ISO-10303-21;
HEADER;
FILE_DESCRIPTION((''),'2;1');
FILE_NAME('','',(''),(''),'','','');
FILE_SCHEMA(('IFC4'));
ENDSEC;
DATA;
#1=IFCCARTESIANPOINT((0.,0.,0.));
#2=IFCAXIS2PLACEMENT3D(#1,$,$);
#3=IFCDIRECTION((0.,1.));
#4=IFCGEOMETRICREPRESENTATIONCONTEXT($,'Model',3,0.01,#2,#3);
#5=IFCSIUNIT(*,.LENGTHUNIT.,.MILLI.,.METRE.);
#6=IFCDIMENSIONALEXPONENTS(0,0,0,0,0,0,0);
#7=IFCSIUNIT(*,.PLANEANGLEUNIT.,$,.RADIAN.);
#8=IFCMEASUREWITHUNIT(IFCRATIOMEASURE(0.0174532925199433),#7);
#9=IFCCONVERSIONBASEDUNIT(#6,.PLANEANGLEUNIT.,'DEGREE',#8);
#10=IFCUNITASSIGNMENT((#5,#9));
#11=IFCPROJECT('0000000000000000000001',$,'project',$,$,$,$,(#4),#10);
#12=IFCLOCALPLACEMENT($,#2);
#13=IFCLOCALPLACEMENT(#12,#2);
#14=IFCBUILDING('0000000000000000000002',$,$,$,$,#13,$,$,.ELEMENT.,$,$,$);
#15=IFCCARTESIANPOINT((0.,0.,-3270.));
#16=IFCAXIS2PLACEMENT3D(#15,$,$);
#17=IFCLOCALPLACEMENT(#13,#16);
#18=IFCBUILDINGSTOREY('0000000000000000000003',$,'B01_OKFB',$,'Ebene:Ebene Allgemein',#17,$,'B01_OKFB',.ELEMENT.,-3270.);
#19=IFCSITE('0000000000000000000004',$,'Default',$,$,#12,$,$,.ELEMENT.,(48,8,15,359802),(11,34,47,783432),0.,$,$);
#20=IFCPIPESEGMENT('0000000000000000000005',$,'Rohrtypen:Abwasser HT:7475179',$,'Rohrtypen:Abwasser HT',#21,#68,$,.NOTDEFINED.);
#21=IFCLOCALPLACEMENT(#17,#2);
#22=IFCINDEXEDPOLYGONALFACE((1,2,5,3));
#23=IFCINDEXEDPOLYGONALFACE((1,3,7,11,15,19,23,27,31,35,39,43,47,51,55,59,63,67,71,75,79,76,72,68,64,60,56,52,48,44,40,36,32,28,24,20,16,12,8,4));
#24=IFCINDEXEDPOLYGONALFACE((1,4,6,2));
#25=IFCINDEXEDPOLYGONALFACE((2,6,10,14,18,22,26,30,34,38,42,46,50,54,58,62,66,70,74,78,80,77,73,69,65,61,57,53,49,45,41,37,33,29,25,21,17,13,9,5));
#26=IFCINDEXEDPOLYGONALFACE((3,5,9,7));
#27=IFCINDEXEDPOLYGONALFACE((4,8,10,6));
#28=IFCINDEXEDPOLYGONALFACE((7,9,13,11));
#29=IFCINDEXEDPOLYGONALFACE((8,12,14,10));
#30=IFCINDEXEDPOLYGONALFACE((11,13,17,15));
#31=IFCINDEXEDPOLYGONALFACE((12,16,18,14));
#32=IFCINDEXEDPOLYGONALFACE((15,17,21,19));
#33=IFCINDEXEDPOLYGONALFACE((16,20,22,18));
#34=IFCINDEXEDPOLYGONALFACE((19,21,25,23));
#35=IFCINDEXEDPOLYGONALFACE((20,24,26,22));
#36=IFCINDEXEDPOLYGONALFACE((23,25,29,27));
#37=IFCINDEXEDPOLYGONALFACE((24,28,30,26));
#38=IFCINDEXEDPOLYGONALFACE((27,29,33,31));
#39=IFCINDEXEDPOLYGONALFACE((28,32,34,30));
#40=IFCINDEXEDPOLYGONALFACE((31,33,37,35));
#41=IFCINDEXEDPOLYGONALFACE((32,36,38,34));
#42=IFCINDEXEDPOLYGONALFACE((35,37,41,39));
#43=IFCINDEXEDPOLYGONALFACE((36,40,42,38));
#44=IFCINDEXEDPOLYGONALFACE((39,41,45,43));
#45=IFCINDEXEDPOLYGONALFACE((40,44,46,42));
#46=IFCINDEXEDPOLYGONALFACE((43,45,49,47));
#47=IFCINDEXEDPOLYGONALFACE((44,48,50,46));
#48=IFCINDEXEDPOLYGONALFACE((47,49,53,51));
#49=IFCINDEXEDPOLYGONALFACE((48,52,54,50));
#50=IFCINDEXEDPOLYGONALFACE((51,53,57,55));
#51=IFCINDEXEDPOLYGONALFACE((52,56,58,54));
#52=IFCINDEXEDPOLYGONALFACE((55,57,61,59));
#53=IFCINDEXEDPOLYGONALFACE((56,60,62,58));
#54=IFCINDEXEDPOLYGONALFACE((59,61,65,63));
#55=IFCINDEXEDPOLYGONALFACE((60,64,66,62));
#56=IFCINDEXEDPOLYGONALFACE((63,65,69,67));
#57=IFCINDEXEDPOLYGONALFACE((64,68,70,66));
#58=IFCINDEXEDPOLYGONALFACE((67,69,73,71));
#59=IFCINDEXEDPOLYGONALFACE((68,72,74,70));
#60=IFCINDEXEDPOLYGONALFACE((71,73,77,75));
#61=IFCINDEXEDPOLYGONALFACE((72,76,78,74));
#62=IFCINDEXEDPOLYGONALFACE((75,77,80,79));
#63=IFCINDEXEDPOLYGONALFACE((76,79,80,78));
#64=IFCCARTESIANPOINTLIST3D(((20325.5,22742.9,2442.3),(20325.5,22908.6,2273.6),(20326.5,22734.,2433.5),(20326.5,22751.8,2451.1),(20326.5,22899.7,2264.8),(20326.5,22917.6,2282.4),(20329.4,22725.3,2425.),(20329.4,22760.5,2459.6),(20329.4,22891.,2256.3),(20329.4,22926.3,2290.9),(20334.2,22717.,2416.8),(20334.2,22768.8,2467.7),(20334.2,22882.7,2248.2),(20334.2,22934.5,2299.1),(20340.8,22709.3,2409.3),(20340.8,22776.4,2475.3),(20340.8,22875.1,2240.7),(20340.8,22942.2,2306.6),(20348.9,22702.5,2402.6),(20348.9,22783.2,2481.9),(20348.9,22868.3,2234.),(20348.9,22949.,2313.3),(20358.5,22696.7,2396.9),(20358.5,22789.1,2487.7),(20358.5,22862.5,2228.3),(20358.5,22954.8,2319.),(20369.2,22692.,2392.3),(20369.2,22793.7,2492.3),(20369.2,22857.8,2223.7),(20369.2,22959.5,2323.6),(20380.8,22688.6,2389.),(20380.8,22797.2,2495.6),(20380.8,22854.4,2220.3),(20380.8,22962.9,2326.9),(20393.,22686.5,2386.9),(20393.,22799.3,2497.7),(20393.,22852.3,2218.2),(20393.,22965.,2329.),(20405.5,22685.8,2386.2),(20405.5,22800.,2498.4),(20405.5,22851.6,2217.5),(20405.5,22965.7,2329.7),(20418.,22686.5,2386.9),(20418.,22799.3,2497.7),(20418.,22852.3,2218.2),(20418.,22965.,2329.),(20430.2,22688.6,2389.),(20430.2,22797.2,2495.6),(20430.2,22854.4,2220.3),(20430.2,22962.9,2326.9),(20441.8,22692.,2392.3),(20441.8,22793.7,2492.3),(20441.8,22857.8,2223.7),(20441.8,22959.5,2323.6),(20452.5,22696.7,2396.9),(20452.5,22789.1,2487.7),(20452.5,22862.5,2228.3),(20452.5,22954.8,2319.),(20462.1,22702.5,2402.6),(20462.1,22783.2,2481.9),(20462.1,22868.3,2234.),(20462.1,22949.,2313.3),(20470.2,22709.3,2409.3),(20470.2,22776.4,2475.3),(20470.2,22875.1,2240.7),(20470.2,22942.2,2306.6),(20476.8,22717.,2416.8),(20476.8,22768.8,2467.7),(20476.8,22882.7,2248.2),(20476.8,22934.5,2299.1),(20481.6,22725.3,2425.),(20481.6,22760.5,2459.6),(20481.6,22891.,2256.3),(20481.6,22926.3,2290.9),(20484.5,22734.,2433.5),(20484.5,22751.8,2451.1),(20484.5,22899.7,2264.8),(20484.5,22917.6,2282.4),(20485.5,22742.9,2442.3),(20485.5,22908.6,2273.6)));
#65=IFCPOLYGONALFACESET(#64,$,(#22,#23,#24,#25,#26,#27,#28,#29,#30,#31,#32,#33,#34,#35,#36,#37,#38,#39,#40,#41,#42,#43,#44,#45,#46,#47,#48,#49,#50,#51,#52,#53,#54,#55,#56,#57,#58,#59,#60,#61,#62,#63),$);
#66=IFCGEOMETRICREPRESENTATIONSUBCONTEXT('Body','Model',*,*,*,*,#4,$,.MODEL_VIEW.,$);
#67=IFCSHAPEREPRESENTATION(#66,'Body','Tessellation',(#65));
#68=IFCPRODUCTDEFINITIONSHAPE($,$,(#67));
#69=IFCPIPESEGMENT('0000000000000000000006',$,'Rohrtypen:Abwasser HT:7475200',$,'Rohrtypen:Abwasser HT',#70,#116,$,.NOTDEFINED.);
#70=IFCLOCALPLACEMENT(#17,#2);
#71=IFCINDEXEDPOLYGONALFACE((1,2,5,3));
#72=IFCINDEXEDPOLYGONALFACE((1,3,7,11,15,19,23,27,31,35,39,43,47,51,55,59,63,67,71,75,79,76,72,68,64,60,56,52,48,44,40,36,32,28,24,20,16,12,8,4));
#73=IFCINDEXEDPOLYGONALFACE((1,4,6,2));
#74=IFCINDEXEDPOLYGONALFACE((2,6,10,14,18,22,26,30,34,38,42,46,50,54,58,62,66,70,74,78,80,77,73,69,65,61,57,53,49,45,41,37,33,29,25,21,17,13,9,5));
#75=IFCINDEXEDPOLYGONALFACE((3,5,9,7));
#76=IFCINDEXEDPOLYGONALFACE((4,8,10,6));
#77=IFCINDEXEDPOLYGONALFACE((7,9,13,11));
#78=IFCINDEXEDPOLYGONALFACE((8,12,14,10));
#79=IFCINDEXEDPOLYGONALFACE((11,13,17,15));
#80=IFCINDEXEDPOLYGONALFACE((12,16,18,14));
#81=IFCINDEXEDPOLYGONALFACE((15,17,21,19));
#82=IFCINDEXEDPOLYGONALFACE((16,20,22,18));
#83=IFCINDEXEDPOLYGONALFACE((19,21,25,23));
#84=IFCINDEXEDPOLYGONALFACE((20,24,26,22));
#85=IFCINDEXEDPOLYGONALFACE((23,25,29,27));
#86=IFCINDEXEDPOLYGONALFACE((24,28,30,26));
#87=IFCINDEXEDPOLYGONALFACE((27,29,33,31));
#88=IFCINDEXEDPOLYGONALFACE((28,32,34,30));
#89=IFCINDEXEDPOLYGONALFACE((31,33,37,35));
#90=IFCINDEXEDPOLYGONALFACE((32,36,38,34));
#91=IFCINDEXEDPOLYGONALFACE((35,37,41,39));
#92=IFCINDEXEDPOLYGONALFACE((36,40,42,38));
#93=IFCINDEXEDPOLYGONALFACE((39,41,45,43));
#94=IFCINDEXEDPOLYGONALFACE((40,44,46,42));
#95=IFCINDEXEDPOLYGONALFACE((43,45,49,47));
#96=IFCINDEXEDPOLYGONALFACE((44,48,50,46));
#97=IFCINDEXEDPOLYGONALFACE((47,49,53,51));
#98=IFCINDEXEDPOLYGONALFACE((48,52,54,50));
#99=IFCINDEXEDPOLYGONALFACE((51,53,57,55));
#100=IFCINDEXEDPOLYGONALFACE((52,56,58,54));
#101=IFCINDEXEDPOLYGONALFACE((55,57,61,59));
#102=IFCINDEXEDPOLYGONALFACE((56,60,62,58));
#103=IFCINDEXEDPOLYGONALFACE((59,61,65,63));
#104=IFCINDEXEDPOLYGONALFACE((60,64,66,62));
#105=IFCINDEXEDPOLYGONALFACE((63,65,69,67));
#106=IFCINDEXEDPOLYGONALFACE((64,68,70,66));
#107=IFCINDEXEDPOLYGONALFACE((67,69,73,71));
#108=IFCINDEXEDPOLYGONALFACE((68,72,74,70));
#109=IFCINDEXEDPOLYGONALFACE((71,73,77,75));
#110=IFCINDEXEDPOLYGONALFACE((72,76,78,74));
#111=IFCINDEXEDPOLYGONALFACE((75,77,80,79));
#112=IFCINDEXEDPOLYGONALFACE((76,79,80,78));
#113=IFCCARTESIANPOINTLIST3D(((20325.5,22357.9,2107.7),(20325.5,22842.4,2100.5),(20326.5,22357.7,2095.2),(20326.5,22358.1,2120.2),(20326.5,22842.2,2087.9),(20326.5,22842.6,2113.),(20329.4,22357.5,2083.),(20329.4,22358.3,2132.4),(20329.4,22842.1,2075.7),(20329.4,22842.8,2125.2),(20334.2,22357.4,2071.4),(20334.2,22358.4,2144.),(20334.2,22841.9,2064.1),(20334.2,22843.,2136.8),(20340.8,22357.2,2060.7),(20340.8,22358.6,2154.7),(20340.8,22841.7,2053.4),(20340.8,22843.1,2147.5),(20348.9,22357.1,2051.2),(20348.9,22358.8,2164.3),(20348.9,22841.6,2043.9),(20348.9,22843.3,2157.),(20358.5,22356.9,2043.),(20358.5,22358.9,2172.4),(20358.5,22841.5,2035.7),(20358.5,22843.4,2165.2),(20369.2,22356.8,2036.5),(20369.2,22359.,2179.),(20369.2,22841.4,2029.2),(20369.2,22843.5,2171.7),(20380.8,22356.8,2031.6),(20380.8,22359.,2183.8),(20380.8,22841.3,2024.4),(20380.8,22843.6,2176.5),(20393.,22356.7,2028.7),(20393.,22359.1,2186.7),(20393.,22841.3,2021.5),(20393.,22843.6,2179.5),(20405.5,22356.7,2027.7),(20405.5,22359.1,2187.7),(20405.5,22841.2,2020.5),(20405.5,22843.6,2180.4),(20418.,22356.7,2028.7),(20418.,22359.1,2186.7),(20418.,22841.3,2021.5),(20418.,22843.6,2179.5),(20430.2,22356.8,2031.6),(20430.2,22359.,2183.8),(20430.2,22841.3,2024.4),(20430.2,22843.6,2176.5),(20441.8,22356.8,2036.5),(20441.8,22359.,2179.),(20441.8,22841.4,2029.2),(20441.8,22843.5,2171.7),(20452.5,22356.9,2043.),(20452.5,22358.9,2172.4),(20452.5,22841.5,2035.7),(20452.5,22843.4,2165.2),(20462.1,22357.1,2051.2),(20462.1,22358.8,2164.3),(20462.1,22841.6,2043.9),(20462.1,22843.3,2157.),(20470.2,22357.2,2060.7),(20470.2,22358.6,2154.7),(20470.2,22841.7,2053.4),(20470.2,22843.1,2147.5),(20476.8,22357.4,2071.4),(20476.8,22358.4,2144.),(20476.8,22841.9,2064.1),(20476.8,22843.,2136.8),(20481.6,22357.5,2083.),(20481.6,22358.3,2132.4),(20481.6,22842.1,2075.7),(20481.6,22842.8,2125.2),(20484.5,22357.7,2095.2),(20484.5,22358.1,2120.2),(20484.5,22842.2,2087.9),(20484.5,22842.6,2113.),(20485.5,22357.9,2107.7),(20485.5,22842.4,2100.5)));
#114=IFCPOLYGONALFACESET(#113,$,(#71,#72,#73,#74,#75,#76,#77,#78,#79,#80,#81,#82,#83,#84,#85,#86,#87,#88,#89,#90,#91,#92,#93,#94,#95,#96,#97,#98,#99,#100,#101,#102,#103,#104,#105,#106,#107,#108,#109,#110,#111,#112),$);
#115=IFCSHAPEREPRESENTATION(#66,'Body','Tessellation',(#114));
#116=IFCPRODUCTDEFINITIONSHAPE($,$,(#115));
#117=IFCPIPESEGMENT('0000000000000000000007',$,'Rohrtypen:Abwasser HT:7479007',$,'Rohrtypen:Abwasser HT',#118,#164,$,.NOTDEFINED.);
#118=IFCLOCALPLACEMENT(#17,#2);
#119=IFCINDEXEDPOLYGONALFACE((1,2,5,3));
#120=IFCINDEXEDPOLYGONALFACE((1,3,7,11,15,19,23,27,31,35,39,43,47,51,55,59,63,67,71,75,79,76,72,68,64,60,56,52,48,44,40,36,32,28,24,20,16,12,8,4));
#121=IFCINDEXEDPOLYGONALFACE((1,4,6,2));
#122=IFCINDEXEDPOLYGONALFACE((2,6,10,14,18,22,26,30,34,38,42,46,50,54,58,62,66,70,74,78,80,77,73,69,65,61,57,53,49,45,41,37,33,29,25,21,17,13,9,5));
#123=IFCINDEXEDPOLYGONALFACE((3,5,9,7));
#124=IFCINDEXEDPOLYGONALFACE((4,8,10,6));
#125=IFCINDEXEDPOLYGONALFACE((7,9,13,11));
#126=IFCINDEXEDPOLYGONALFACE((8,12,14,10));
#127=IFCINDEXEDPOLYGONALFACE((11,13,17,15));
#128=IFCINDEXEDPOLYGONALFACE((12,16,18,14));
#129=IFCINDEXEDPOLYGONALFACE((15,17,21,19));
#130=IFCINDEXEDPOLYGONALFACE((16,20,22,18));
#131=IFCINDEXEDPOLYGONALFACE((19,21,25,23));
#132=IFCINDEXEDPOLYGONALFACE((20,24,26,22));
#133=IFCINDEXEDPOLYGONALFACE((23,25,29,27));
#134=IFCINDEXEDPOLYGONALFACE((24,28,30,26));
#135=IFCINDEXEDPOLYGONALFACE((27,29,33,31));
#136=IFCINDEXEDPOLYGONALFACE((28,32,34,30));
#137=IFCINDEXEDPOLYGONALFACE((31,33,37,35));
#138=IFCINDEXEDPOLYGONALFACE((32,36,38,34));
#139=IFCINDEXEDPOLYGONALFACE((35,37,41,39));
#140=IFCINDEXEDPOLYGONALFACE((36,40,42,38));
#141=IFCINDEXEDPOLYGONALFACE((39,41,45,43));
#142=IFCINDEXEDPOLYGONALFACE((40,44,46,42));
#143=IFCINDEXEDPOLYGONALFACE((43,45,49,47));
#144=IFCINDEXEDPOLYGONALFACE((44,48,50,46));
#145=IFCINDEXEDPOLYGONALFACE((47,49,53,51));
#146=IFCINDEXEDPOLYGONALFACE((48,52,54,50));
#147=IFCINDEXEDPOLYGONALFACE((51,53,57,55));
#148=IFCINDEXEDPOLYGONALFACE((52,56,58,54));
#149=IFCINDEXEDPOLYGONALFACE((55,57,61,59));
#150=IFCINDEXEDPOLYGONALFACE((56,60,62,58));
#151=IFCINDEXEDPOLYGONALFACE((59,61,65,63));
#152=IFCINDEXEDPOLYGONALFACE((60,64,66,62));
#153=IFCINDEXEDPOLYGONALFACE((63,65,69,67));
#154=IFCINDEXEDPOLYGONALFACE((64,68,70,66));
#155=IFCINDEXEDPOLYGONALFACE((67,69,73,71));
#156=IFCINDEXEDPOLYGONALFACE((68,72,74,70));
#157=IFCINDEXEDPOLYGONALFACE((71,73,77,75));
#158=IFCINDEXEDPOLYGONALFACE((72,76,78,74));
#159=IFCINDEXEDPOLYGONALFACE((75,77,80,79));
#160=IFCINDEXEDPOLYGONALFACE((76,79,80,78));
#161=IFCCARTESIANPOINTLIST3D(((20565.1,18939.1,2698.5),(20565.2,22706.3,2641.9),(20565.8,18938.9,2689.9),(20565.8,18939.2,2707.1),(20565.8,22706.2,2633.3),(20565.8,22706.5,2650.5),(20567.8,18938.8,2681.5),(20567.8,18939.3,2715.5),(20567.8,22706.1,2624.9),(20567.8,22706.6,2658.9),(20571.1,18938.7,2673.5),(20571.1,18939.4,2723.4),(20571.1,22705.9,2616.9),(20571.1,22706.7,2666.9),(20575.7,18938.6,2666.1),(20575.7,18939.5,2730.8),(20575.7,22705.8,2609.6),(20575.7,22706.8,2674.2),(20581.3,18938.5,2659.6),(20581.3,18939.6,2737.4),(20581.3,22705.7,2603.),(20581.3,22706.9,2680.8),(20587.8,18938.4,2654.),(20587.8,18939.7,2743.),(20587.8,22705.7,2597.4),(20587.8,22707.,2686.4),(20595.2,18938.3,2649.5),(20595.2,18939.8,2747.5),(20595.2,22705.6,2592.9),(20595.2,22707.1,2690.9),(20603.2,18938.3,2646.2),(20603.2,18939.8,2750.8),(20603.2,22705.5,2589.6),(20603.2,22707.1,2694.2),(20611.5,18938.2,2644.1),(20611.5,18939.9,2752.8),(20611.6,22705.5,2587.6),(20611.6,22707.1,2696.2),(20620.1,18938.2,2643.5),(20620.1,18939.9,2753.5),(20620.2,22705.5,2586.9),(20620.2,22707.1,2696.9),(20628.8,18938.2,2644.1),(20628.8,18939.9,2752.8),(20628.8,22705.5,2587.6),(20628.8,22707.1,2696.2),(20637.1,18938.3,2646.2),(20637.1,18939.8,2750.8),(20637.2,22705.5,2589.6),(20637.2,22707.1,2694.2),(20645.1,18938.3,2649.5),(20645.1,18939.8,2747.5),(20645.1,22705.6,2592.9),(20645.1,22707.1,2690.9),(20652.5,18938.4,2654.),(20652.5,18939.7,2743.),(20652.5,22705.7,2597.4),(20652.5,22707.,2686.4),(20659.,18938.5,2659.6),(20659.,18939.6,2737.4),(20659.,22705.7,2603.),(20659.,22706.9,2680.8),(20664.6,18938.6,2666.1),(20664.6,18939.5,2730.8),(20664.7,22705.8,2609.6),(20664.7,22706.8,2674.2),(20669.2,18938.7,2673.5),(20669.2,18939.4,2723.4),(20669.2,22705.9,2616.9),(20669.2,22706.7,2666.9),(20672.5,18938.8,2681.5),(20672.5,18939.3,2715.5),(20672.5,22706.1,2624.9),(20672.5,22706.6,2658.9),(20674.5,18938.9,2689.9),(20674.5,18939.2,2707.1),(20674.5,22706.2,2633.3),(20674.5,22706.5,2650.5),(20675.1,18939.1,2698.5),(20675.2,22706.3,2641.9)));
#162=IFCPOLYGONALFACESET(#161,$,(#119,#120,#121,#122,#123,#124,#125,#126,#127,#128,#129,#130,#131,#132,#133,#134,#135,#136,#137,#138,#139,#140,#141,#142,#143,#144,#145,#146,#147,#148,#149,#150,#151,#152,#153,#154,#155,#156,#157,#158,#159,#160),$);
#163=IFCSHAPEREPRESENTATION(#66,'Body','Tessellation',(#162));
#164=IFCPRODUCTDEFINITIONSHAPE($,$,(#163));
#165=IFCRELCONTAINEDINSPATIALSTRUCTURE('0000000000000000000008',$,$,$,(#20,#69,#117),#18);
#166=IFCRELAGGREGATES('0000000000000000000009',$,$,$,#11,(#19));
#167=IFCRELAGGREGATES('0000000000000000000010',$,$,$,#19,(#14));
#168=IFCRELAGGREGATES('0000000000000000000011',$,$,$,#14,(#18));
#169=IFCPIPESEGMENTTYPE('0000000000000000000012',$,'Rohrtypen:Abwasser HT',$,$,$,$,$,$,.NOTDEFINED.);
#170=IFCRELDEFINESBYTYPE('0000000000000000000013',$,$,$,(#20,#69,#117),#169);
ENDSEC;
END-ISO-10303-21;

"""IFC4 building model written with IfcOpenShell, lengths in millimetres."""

from ifc_helpers import new_model, entity, si_unit, converted_unit, direction, frame, origin, place, context, subcontext, project, spatial, indexed_curve, outline, extrude, type_object, element, save


model = new_model("IFC4")

# Units and contexts
model_context = context("Model", 3, precision=0.01, world=origin(), true_north=direction((0.0, 1.0)))
body_context = subcontext(model_context, "Body", "Model", "MODEL_VIEW")
ifc_project = project(units=[si_unit("LENGTHUNIT", "METRE", prefix="MILLI"), converted_unit("PLANEANGLEUNIT", "DEGREE", entity("IfcRatioMeasure", 0.0174532925199433), si_unit("PLANEANGLEUNIT", "RADIAN"), dimensions=[0, 0, 0, 0, 0, 0, 0])], contexts=[model_context])

# Site, building, storey
site_placement = place(None, origin())
site = spatial("IfcSite", under=ifc_project, at=site_placement, Name="Default", CompositionType="ELEMENT", RefLatitude=(48, 8, 15, 359802), RefLongitude=(11, 34, 47, 783432), RefElevation=0.0)
building_placement = place(site_placement, origin())
building = spatial("IfcBuilding", under=site, at=building_placement, CompositionType="ELEMENT")
storey_placement = place(building_placement, frame((0.0, 0.0, -3270.0)))
storey = spatial("IfcBuildingStorey", under=building, at=storey_placement, Name="B01_OKFB", ObjectType="Ebene:Ebene Allgemein", LongName="B01_OKFB", CompositionType="ELEMENT", Elevation=-3270.0)

# Pipe segments
pipe_segment_type_1 = type_object("IfcPipeSegmentType", Name="Rohrtypen:Abwasser HT", PredefinedType="NOTDEFINED")
pipe_segment_1_placement = place(storey_placement, origin())
element("IfcPipeSegment", 1, at=pipe_segment_1_placement, inside=storey, type_object=pipe_segment_type_1, Name="Rohrtypen:Abwasser HT:7475179", ObjectType="Rohrtypen:Abwasser HT", PredefinedType="NOTDEFINED", context=body_context, shape_type="SweptSolid", body=[
    extrude(outline(indexed_curve([(80.0, 0.0), (79.0, 12.5), (76.1, 24.7), (71.3, 36.3), (64.7, 47.0), (56.6, 56.6), (47.0, 64.7), (36.3, 71.3), (24.7, 76.1), (12.5, 79.0), (0.0, 80.0), (-12.5, 79.0), (-24.7, 76.1), (-36.3, 71.3), (-47.0, 64.7), (-56.6, 56.6), (-64.7, 47.0), (-71.3, 36.3), (-76.1, 24.7), (-79.0, 12.5), (-80.0, 0.0), (-79.0, -12.5), (-76.1, -24.7), (-71.3, -36.3), (-64.7, -47.0), (-56.6, -56.6), (-47.0, -64.7), (-36.3, -71.3), (-24.7, -76.1), (-12.5, -79.0), (0.0, -80.0), (12.5, -79.0), (24.7, -76.1), (36.3, -71.3), (47.0, -64.7), (56.6, -56.6), (64.7, -47.0), (71.3, -36.3), (76.1, -24.7), (79.0, -12.5), (80.0, 0.0)], self_intersect=False)), frame((20405.5, 22742.9, 2442.3), z_axis=(0.0, 0.700866, -0.713293), x_axis=(-1.0, 0.0, 0.0)), (0.0, 0.0, 1.0), 236.5),
])
pipe_segment_2_placement = place(storey_placement, origin())
element("IfcPipeSegment", 2, at=pipe_segment_2_placement, inside=storey, type_object=pipe_segment_type_1, Name="Rohrtypen:Abwasser HT:7475200", ObjectType="Rohrtypen:Abwasser HT", PredefinedType="NOTDEFINED", context=body_context, shape_type="SweptSolid", body=[
    extrude(outline(indexed_curve([(80.0, 0.0), (79.0, 12.5), (76.1, 24.7), (71.3, 36.3), (64.7, 47.0), (56.6, 56.6), (47.0, 64.7), (36.3, 71.3), (24.7, 76.1), (12.5, 79.0), (0.0, 80.0), (-12.5, 79.0), (-24.7, 76.1), (-36.3, 71.3), (-47.0, 64.7), (-56.6, 56.6), (-64.7, 47.0), (-71.3, 36.3), (-76.1, 24.7), (-79.0, 12.5), (-80.0, 0.0), (-79.0, -12.5), (-76.1, -24.7), (-71.3, -36.3), (-64.7, -47.0), (-56.6, -56.6), (-47.0, -64.7), (-36.3, -71.3), (-24.7, -76.1), (-12.5, -79.0), (0.0, -80.0), (12.5, -79.0), (24.7, -76.1), (36.3, -71.3), (47.0, -64.7), (56.6, -56.6), (64.7, -47.0), (71.3, -36.3), (76.1, -24.7), (79.0, -12.5), (80.0, 0.0)], self_intersect=False)), frame((20405.5, 22357.9, 2107.7), z_axis=(0.0, 0.999888, -0.014998), x_axis=(1.0, 0.0, 0.0)), (0.0, 0.0, 1.0), 484.6),
])
pipe_segment_3_placement = place(storey_placement, origin())
element("IfcPipeSegment", 3, at=pipe_segment_3_placement, inside=storey, type_object=pipe_segment_type_1, Name="Rohrtypen:Abwasser HT:7479007", ObjectType="Rohrtypen:Abwasser HT", PredefinedType="NOTDEFINED", context=body_context, shape_type="SweptSolid", body=[
    extrude(outline(indexed_curve([(55.0, 0.0), (54.3, 8.6), (52.3, 17.0), (49.0, 25.0), (44.5, 32.3), (38.9, 38.9), (32.3, 44.5), (25.0, 49.0), (17.0, 52.3), (8.6, 54.3), (0.0, 55.0), (-8.6, 54.3), (-17.0, 52.3), (-25.0, 49.0), (-32.3, 44.5), (-38.9, 38.9), (-44.5, 32.3), (-49.0, 25.0), (-52.3, 17.0), (-54.3, 8.6), (-55.0, 0.0), (-54.3, -8.6), (-52.3, -17.0), (-49.0, -25.0), (-44.5, -32.3), (-38.9, -38.9), (-32.3, -44.5), (-25.0, -49.0), (-17.0, -52.3), (-8.6, -54.3), (0.0, -55.0), (8.6, -54.3), (17.0, -52.3), (25.0, -49.0), (32.3, -44.5), (38.9, -38.9), (44.5, -32.3), (49.0, -25.0), (52.3, -17.0), (54.3, -8.6), (55.0, 0.0)], self_intersect=False)), frame((20620.1, 18939.1, 2698.5), z_axis=(0.000002, 0.999887, -0.01501), x_axis=(1.0, -0.000002, 0.0)), (0.0, 0.0, 1.0), 3767.7),
])

save(model, "model.ifc")
